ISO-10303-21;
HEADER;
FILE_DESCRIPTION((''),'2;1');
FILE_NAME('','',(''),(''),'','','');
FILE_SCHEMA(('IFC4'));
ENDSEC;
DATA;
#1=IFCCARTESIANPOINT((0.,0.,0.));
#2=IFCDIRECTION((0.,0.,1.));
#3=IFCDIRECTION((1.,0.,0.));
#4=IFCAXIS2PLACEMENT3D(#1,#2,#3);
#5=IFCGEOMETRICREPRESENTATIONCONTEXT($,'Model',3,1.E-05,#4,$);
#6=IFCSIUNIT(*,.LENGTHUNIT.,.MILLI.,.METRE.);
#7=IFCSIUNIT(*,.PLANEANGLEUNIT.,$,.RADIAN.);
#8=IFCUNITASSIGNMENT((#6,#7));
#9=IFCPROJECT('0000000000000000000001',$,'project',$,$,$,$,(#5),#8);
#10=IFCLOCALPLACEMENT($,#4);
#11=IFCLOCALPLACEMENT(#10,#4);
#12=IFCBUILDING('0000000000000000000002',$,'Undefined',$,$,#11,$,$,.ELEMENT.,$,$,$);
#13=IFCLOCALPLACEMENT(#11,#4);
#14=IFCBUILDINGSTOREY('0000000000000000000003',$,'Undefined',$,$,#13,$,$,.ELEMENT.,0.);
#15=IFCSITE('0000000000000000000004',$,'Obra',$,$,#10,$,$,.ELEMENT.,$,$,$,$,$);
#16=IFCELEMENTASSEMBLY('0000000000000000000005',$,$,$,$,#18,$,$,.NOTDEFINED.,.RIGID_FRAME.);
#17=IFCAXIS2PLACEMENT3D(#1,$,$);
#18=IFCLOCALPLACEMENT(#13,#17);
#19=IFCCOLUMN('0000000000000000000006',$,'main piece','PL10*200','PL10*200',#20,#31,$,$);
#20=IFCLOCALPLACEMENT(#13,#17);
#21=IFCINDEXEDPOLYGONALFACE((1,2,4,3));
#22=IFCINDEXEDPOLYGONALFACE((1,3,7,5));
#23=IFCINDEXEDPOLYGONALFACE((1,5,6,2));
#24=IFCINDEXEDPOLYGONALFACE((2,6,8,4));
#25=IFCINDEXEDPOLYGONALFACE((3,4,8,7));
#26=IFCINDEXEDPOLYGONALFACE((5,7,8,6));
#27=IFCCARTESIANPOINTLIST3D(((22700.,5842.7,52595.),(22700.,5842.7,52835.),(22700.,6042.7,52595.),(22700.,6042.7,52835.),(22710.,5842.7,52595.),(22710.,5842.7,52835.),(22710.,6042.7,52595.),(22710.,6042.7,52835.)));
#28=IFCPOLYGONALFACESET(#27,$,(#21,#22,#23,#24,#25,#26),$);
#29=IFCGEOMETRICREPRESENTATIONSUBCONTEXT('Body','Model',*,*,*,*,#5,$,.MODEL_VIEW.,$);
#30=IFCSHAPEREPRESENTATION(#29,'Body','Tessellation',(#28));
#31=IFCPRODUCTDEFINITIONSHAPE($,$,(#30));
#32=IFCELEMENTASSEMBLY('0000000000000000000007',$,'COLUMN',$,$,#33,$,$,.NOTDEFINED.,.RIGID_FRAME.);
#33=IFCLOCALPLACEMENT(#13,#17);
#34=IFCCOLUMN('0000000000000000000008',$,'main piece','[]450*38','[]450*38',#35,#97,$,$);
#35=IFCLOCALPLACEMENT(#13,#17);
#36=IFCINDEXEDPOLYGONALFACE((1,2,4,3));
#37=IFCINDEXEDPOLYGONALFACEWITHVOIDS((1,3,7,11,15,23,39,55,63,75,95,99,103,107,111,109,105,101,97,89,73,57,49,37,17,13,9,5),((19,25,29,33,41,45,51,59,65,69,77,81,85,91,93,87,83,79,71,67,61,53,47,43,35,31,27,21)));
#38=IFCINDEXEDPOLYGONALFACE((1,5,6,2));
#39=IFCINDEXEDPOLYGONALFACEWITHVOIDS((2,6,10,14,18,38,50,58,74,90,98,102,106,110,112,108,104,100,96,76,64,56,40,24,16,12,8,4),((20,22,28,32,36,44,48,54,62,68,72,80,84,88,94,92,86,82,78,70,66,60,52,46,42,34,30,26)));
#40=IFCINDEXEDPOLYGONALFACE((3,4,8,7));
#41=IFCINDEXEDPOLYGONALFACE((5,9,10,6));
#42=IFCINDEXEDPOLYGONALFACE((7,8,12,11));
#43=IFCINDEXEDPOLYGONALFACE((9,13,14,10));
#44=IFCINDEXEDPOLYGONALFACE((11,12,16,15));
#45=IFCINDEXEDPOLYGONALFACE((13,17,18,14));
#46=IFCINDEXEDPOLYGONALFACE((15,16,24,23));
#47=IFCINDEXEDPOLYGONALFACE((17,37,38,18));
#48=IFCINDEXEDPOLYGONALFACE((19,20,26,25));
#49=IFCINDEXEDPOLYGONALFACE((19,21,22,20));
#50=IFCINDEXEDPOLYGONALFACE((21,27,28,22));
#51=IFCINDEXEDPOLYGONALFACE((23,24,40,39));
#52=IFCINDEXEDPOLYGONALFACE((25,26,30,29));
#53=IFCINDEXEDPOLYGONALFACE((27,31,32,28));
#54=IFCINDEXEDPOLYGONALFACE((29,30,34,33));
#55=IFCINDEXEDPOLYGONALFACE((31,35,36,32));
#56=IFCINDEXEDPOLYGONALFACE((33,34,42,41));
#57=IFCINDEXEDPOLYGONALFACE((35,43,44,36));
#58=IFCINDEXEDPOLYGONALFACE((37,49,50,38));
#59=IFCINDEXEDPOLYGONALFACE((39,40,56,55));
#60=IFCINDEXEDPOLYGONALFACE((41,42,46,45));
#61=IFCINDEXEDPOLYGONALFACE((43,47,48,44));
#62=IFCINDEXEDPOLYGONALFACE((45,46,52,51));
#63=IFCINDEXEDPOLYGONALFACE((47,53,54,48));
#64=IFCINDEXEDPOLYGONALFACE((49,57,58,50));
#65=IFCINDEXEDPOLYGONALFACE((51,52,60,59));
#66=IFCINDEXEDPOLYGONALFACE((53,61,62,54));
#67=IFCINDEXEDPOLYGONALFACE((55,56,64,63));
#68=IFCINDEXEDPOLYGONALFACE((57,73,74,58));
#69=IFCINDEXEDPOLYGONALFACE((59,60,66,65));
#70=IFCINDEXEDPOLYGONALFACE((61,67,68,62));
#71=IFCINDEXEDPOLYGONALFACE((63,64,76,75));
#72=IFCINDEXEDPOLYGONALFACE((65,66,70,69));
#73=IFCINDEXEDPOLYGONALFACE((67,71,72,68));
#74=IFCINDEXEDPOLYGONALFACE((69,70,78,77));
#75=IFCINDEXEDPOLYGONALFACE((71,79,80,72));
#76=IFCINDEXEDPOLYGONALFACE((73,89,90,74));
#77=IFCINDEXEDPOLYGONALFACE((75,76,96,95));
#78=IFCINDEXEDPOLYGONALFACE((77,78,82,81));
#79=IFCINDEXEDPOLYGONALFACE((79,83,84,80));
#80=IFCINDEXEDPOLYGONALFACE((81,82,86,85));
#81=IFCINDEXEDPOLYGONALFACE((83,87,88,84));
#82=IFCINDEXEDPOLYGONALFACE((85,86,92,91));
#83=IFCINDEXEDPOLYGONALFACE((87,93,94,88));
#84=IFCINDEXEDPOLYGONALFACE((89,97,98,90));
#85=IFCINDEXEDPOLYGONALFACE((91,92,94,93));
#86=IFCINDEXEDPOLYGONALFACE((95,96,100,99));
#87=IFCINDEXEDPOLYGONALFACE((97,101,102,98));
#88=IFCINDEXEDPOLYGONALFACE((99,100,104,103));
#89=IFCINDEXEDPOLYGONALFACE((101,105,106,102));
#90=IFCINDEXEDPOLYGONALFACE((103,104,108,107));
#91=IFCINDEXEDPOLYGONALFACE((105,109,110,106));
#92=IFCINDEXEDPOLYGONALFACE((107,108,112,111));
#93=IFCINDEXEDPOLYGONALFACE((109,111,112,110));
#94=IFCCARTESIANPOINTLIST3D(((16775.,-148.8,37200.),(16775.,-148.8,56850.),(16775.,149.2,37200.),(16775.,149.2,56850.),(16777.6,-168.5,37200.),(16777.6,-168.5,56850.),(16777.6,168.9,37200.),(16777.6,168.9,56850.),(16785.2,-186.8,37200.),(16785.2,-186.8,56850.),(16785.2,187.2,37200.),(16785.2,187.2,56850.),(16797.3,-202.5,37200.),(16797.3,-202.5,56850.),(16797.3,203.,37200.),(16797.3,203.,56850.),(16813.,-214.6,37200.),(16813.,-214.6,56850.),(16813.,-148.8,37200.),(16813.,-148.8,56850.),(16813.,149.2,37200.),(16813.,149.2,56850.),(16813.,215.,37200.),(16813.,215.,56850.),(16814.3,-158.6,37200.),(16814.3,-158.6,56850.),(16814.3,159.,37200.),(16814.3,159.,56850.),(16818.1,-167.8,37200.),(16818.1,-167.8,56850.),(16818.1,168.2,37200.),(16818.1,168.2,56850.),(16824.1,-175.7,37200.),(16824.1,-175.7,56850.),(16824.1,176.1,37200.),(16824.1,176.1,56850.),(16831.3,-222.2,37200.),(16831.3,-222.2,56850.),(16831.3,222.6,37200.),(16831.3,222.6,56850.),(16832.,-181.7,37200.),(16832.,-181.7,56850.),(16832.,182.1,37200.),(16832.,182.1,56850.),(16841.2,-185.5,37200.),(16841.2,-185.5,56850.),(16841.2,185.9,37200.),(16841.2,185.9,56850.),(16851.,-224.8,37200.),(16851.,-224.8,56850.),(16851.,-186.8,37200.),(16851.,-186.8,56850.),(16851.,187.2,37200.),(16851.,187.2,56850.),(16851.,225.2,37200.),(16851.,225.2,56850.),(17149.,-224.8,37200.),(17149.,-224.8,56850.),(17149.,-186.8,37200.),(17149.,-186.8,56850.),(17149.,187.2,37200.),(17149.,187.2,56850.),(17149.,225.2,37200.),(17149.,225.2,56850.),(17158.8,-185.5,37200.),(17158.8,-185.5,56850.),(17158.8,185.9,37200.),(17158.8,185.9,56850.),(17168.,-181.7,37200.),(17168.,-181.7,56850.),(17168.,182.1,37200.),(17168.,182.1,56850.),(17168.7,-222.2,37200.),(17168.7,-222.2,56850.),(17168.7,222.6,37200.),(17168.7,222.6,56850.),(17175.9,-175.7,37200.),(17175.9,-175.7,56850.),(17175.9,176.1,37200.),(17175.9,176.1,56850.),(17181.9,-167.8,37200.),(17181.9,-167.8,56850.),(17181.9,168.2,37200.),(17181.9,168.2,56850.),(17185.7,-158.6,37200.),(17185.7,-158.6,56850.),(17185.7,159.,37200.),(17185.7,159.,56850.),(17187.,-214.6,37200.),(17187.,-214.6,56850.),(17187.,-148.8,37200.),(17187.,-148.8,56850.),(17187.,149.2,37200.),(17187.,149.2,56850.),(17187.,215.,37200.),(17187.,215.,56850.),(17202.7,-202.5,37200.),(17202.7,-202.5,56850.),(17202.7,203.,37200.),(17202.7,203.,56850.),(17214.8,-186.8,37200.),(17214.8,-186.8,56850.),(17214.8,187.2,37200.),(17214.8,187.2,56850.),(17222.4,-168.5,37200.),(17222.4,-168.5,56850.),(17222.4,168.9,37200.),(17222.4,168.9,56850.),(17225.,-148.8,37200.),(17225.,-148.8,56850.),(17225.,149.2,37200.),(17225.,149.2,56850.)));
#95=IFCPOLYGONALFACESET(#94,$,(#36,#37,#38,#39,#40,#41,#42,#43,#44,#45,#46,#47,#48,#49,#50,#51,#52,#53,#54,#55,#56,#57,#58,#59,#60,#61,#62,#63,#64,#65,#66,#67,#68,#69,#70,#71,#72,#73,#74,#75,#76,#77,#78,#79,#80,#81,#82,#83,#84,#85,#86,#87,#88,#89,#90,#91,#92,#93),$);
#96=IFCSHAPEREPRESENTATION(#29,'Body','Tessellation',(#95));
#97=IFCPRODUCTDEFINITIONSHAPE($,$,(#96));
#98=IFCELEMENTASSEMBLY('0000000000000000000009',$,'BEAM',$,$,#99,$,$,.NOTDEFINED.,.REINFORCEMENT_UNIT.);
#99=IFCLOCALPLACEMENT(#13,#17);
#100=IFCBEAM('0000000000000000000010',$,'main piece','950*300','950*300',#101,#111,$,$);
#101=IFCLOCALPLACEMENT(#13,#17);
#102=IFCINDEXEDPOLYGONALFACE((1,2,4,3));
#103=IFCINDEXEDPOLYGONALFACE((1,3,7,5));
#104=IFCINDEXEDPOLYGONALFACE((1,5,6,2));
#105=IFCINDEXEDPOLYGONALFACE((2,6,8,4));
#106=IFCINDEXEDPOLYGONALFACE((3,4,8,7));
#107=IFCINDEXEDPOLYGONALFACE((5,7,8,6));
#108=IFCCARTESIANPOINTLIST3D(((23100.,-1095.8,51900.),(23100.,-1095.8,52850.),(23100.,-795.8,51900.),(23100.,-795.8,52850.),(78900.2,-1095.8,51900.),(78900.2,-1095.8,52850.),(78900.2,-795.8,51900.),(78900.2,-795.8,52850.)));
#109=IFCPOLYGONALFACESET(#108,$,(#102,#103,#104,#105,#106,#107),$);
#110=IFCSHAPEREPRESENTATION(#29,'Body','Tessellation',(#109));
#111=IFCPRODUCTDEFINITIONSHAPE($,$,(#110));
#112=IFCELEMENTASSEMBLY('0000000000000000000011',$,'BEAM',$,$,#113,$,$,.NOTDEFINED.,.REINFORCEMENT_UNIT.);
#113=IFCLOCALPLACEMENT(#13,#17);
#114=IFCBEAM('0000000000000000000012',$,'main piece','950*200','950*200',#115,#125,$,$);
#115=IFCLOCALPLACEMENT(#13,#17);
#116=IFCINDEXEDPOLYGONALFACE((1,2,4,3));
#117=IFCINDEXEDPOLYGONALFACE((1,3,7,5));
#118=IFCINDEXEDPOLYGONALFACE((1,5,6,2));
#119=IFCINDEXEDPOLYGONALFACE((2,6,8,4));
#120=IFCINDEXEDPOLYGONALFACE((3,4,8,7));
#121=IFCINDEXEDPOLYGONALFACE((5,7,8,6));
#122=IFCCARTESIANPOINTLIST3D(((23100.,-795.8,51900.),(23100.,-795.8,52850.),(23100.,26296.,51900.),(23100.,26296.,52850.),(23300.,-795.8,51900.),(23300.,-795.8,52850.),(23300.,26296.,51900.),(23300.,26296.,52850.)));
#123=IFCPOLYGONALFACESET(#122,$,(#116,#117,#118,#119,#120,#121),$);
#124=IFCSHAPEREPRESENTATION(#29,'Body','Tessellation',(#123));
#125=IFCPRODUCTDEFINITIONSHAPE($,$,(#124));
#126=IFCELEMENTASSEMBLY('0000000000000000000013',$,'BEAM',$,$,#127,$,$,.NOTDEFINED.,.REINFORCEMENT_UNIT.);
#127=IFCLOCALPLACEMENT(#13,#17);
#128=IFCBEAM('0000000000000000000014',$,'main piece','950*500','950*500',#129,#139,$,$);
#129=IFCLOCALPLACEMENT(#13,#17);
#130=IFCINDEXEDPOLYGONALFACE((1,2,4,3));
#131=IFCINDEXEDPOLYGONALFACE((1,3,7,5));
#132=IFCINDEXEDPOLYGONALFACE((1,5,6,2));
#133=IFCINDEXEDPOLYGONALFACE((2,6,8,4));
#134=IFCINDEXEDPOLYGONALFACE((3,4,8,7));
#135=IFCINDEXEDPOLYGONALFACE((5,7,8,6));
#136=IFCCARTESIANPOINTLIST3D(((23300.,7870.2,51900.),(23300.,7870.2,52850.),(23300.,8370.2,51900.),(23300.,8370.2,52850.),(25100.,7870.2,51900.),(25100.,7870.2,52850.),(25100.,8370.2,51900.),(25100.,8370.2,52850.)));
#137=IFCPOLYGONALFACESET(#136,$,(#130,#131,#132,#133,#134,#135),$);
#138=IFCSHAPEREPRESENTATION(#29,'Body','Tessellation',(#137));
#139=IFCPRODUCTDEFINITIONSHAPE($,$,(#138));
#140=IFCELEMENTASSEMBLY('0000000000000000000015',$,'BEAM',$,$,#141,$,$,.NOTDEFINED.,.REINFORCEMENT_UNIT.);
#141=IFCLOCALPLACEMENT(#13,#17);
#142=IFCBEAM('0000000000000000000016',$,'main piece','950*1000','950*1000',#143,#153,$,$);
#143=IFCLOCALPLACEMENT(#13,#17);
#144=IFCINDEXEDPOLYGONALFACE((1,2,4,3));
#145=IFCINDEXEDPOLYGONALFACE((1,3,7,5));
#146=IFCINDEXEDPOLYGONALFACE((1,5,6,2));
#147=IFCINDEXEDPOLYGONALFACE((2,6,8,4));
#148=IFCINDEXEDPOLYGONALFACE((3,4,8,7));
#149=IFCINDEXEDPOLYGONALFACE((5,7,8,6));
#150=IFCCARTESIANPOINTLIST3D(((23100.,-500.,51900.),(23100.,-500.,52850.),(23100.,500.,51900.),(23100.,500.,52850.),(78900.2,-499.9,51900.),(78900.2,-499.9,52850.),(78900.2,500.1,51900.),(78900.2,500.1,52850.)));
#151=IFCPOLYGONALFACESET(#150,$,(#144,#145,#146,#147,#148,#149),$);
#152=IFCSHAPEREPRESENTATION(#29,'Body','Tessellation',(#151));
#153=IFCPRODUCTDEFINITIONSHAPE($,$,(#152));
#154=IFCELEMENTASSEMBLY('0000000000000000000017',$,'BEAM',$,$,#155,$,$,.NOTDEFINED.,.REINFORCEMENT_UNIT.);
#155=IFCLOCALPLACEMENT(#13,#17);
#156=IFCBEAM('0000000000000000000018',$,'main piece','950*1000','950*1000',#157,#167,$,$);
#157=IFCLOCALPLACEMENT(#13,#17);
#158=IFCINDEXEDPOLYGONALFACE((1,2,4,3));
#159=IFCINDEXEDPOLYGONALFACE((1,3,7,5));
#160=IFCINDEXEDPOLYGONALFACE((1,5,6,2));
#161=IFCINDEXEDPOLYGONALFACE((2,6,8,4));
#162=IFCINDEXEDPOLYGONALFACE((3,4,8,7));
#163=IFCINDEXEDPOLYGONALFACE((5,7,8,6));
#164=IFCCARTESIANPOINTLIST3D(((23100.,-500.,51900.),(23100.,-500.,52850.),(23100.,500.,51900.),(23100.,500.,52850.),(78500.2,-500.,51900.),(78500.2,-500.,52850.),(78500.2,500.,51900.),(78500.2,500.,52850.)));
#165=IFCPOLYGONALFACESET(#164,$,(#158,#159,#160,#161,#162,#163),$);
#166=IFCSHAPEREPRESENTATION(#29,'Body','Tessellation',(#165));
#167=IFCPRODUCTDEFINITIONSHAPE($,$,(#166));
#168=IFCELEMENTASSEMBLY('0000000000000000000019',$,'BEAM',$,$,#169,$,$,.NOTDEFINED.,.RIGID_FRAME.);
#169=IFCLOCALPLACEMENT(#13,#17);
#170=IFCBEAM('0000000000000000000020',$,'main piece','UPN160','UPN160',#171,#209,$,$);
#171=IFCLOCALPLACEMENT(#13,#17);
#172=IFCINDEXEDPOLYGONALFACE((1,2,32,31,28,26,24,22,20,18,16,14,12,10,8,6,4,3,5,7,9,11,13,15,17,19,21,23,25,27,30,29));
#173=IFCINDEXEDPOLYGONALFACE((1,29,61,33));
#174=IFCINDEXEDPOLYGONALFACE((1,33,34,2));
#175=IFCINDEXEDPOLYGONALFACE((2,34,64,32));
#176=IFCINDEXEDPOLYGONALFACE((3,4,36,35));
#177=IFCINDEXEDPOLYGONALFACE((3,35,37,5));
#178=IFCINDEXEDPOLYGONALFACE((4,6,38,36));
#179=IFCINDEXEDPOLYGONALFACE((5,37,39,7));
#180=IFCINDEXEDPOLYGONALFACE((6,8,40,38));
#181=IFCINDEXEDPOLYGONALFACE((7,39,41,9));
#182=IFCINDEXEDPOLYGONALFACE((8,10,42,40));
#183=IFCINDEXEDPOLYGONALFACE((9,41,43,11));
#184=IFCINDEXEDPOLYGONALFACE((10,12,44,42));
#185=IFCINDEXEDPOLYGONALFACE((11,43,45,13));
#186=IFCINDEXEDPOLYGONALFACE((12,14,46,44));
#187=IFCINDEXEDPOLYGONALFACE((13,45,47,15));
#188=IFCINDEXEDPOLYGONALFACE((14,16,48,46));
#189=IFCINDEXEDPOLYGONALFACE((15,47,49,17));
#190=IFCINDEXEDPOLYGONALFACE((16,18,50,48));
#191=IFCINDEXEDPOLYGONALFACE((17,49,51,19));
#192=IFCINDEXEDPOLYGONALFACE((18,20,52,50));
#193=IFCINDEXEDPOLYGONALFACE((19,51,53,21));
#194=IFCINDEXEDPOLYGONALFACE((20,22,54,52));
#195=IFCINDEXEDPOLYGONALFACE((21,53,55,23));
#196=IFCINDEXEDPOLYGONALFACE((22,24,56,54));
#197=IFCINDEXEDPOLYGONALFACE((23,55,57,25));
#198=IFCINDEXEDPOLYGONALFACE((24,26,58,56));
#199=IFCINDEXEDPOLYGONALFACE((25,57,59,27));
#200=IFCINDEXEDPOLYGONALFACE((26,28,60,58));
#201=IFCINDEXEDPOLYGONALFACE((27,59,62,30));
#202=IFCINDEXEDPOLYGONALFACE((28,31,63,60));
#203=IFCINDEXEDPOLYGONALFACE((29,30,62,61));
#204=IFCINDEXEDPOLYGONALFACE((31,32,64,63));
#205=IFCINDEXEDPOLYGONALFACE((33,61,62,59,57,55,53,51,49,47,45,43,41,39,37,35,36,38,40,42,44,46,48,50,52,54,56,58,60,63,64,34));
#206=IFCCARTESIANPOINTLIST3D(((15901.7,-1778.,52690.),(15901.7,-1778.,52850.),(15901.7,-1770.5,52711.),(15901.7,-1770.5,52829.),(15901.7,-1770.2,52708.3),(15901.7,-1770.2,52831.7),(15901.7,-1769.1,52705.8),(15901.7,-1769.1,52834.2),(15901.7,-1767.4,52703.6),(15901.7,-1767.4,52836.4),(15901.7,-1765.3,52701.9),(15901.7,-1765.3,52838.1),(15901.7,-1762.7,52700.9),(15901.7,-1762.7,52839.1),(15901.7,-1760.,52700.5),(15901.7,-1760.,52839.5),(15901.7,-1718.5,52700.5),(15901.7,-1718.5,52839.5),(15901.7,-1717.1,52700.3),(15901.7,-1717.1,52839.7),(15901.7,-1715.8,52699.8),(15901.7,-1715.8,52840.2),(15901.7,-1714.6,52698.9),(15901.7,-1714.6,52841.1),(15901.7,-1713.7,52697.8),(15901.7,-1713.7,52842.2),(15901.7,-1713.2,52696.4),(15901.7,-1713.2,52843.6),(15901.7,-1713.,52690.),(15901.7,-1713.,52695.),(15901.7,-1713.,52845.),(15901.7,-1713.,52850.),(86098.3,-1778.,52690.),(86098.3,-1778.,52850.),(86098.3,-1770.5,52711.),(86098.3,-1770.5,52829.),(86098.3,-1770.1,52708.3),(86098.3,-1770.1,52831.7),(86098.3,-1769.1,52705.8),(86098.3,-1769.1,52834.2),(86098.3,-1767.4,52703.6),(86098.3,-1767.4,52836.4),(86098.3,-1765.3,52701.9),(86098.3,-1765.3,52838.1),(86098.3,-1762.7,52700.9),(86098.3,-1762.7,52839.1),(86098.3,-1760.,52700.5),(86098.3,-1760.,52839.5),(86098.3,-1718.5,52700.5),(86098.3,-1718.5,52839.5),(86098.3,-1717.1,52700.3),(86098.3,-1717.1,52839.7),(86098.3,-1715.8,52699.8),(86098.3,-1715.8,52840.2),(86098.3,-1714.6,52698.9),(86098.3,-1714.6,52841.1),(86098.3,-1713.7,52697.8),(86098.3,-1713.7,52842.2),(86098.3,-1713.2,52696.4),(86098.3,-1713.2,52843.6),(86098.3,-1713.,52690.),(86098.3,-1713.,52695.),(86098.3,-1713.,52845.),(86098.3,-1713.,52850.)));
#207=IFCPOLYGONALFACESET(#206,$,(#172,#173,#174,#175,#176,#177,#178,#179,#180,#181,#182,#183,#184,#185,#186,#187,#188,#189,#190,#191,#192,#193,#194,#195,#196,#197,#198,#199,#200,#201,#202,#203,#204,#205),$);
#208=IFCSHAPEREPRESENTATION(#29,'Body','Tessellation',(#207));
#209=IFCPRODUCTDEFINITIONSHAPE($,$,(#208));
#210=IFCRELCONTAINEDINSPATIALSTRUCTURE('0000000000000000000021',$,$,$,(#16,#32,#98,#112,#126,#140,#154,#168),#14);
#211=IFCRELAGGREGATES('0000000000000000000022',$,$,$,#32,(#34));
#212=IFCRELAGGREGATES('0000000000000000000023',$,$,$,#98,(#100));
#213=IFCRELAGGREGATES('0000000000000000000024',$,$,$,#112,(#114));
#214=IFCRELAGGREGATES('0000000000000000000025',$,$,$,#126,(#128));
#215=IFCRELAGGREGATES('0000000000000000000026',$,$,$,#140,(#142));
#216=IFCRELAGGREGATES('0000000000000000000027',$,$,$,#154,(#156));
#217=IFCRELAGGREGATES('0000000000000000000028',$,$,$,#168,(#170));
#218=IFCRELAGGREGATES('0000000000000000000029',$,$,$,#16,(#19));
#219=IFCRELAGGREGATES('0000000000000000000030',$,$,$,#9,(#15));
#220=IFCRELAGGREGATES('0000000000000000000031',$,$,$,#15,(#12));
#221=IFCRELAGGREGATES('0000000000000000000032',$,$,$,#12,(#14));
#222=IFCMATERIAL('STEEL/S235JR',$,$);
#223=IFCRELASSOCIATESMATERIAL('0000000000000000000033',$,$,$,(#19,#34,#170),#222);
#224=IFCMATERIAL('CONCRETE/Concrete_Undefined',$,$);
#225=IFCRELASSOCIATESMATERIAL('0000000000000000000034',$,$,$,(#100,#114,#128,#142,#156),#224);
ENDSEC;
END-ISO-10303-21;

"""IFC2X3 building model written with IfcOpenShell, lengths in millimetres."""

from ifc_helpers import new_model, si_unit, frame, origin_with_axes, origin_2d_with_axis, place, context, subcontext, project, spatial, rectangle, hollow_rectangle, u_section, extrude, material, element, aggregate, save


model = new_model("IFC2X3")

# Units and contexts
model_context = context("Model", 3, precision=1e-05, world=origin_with_axes())
body_context = subcontext(model_context, "Body", "Model", "MODEL_VIEW")
ifc_project = project(units=[si_unit("LENGTHUNIT", "METRE", prefix="MILLI"), si_unit("PLANEANGLEUNIT", "RADIAN")], contexts=[model_context])

# Site, building, storey
site_placement = place(None, origin_with_axes())
site = spatial("IfcSite", under=ifc_project, at=site_placement, Name="Obra", CompositionType="ELEMENT")
building_placement = place(site_placement, origin_with_axes())
building = spatial("IfcBuilding", under=site, at=building_placement, Name="Undefined", CompositionType="ELEMENT")
storey_placement = place(building_placement, origin_with_axes())
storey = spatial("IfcBuildingStorey", under=building, at=storey_placement, Name="Undefined", CompositionType="ELEMENT", Elevation=0.0)

# Element assemblies, columns
assembly_1_placement = place(storey_placement, origin_with_axes())
assembly_1 = element("IfcElementAssembly", 1, at=assembly_1_placement, inside=storey, AssemblyPlace="NOTDEFINED", PredefinedType="RIGID_FRAME")
ifc_material_1 = material(Name="STEEL/S235JR")
column_1_placement = place(assembly_1_placement, frame((22705.0, 5942.7, 52595.0), z_axis=(0.0, 0.0, 1.0), x_axis=(0.0, 1.0, 0.0)))
column_1 = element("IfcColumn", 2, at=column_1_placement, material=ifc_material_1, Name="main piece", Description="PL10*200", ObjectType="PL10*200", context=body_context, shape_type="SweptSolid", body=[
    extrude(rectangle(XDim=10.0, YDim=200.0, at=origin_2d_with_axis()), frame((0.0, 0.0, 240.0), z_axis=(0.0, 0.0, -1.0), x_axis=(0.0, 1.0, 0.0)), (0.0, 0.0, 1.0), 240.0),
])
assembly_2_placement = place(storey_placement, origin_with_axes())
assembly_2 = element("IfcElementAssembly", 3, at=assembly_2_placement, inside=storey, Name="COLUMN", AssemblyPlace="NOTDEFINED", PredefinedType="RIGID_FRAME")
column_2_placement = place(assembly_2_placement, frame((17000.0, 0.2, 37200.0), z_axis=(0.0, 0.0, 1.0), x_axis=(0.0, 1.0, 0.0)))
column_2 = element("IfcColumn", 4, at=column_2_placement, material=ifc_material_1, Name="main piece", Description="[]450*38", ObjectType="[]450*38", context=body_context, shape_type="SweptSolid", body=[
    extrude(hollow_rectangle(XDim=450.0, YDim=450.0, WallThickness=38.0, InnerFilletRadius=38.0, OuterFilletRadius=76.0, at=origin_2d_with_axis()), frame((0.0, 0.0, 19650.0), z_axis=(0.0, 0.0, -1.0), x_axis=(0.0, 1.0, 0.0)), (0.0, 0.0, 1.0), 19650.0),
])
aggregate(assembly_2, [column_2])

# Element assemblies, beams
assembly_3_placement = place(storey_placement, origin_with_axes())
assembly_3 = element("IfcElementAssembly", 5, at=assembly_3_placement, inside=storey, Name="BEAM", AssemblyPlace="NOTDEFINED", PredefinedType="REINFORCEMENT_UNIT")
ifc_material_2 = material(Name="CONCRETE/Concrete_Undefined")
beam_1_placement = place(assembly_3_placement, frame((23100.0, -945.8, 52375.0), z_axis=(0.0, 0.0, 1.0), x_axis=(1.0, 0.0, 0.0)))
beam_1 = element("IfcBeam", 6, at=beam_1_placement, material=ifc_material_2, Name="main piece", Description="950*300", ObjectType="950*300", context=body_context, shape_type="SweptSolid", body=[
    extrude(rectangle(XDim=300.0, YDim=950.0, at=origin_2d_with_axis()), frame((55800.2, 0.0, 0.0), z_axis=(-1.0, 0.0, 0.0), x_axis=(0.0, -1.0, 0.0)), (0.0, 0.0, 1.0), 55800.2),
])
aggregate(assembly_3, [beam_1])
assembly_4_placement = place(storey_placement, origin_with_axes())
assembly_4 = element("IfcElementAssembly", 7, at=assembly_4_placement, inside=storey, Name="BEAM", AssemblyPlace="NOTDEFINED", PredefinedType="REINFORCEMENT_UNIT")
beam_2_placement = place(assembly_4_placement, frame((23200.0, -795.8, 52375.0), z_axis=(0.0, 0.0, 1.0), x_axis=(0.0, 1.0, 0.0)))
beam_2 = element("IfcBeam", 8, at=beam_2_placement, material=ifc_material_2, Name="main piece", Description="950*200", ObjectType="950*200", context=body_context, shape_type="SweptSolid", body=[
    extrude(rectangle(XDim=200.0, YDim=950.0, at=origin_2d_with_axis()), frame((27091.8, 0.0, 0.0), z_axis=(-1.0, 0.0, 0.0), x_axis=(0.0, -1.0, 0.0)), (0.0, 0.0, 1.0), 27091.8),
])
aggregate(assembly_4, [beam_2])
assembly_5_placement = place(storey_placement, origin_with_axes())
assembly_5 = element("IfcElementAssembly", 9, at=assembly_5_placement, inside=storey, Name="BEAM", AssemblyPlace="NOTDEFINED", PredefinedType="REINFORCEMENT_UNIT")
beam_3_placement = place(assembly_5_placement, frame((25100.0, 8120.2, 52375.0), z_axis=(0.0, 0.0, 1.0), x_axis=(-1.0, 0.0, 0.0)))
beam_3 = element("IfcBeam", 10, at=beam_3_placement, material=ifc_material_2, Name="main piece", Description="950*500", ObjectType="950*500", context=body_context, shape_type="SweptSolid", body=[
    extrude(rectangle(XDim=500.0, YDim=950.0, at=origin_2d_with_axis()), frame((1800.0, 0.0, 0.0), z_axis=(-1.0, 0.0, 0.0), x_axis=(0.0, -1.0, 0.0)), (0.0, 0.0, 1.0), 1800.0),
])
aggregate(assembly_5, [beam_3])
assembly_6_placement = place(storey_placement, origin_with_axes())
assembly_6 = element("IfcElementAssembly", 11, at=assembly_6_placement, inside=storey, Name="BEAM", AssemblyPlace="NOTDEFINED", PredefinedType="REINFORCEMENT_UNIT")
beam_4_placement = place(assembly_6_placement, frame((23100.0, 0.0, 52375.0), z_axis=(0.0, 0.0, 1.0), x_axis=(1.0, 0.000002, 0.0)))
beam_4 = element("IfcBeam", 12, at=beam_4_placement, material=ifc_material_2, Name="main piece", Description="950*1000", ObjectType="950*1000", context=body_context, shape_type="SweptSolid", body=[
    extrude(rectangle(XDim=1000.0, YDim=950.0, at=origin_2d_with_axis()), frame((55800.2, 0.0, 0.0), z_axis=(-1.0, 0.0, 0.0), x_axis=(0.0, -1.0, 0.0)), (0.0, 0.0, 1.0), 55800.2),
])
aggregate(assembly_6, [beam_4])
assembly_7_placement = place(storey_placement, origin_with_axes())
assembly_7 = element("IfcElementAssembly", 13, at=assembly_7_placement, inside=storey, Name="BEAM", AssemblyPlace="NOTDEFINED", PredefinedType="REINFORCEMENT_UNIT")
beam_5_placement = place(assembly_7_placement, frame((23100.0, 0.0, 52375.0), z_axis=(0.0, 0.0, 1.0), x_axis=(1.0, 0.0, 0.0)))
beam_5 = element("IfcBeam", 14, at=beam_5_placement, material=ifc_material_2, Name="main piece", Description="950*1000", ObjectType="950*1000", context=body_context, shape_type="SweptSolid", body=[
    extrude(rectangle(XDim=1000.0, YDim=950.0, at=origin_2d_with_axis()), frame((55400.2, 0.0, 0.0), z_axis=(-1.0, 0.0, 0.0), x_axis=(0.0, -1.0, 0.0)), (0.0, 0.0, 1.0), 55400.2),
])
aggregate(assembly_7, [beam_5])
assembly_8_placement = place(storey_placement, origin_with_axes())
assembly_8 = element("IfcElementAssembly", 15, at=assembly_8_placement, inside=storey, Name="BEAM", AssemblyPlace="NOTDEFINED", PredefinedType="RIGID_FRAME")
beam_6_placement = place(assembly_8_placement, frame((15901.7, -1745.5, 52770.0), z_axis=(0.0, 0.0, -1.0), x_axis=(1.0, 0.0, 0.0)))
beam_6 = element("IfcBeam", 16, at=beam_6_placement, material=ifc_material_1, Name="main piece", Description="UPN160", ObjectType="UPN160", context=body_context, shape_type="SweptSolid", body=[
    extrude(u_section(Depth=160.0, FlangeWidth=65.0, WebThickness=7.5, FlangeThickness=10.5, FilletRadius=10.5, EdgeRadius=5.5, at=origin_2d_with_axis()), frame((70196.6, 0.0, 0.0), z_axis=(-1.0, 0.0, 0.0), x_axis=(0.0, -1.0, 0.0)), (0.0, 0.0, 1.0), 70196.6),
])
aggregate(assembly_8, [beam_6])

aggregate(assembly_1, [column_1])

save(model, "model.ifc")
